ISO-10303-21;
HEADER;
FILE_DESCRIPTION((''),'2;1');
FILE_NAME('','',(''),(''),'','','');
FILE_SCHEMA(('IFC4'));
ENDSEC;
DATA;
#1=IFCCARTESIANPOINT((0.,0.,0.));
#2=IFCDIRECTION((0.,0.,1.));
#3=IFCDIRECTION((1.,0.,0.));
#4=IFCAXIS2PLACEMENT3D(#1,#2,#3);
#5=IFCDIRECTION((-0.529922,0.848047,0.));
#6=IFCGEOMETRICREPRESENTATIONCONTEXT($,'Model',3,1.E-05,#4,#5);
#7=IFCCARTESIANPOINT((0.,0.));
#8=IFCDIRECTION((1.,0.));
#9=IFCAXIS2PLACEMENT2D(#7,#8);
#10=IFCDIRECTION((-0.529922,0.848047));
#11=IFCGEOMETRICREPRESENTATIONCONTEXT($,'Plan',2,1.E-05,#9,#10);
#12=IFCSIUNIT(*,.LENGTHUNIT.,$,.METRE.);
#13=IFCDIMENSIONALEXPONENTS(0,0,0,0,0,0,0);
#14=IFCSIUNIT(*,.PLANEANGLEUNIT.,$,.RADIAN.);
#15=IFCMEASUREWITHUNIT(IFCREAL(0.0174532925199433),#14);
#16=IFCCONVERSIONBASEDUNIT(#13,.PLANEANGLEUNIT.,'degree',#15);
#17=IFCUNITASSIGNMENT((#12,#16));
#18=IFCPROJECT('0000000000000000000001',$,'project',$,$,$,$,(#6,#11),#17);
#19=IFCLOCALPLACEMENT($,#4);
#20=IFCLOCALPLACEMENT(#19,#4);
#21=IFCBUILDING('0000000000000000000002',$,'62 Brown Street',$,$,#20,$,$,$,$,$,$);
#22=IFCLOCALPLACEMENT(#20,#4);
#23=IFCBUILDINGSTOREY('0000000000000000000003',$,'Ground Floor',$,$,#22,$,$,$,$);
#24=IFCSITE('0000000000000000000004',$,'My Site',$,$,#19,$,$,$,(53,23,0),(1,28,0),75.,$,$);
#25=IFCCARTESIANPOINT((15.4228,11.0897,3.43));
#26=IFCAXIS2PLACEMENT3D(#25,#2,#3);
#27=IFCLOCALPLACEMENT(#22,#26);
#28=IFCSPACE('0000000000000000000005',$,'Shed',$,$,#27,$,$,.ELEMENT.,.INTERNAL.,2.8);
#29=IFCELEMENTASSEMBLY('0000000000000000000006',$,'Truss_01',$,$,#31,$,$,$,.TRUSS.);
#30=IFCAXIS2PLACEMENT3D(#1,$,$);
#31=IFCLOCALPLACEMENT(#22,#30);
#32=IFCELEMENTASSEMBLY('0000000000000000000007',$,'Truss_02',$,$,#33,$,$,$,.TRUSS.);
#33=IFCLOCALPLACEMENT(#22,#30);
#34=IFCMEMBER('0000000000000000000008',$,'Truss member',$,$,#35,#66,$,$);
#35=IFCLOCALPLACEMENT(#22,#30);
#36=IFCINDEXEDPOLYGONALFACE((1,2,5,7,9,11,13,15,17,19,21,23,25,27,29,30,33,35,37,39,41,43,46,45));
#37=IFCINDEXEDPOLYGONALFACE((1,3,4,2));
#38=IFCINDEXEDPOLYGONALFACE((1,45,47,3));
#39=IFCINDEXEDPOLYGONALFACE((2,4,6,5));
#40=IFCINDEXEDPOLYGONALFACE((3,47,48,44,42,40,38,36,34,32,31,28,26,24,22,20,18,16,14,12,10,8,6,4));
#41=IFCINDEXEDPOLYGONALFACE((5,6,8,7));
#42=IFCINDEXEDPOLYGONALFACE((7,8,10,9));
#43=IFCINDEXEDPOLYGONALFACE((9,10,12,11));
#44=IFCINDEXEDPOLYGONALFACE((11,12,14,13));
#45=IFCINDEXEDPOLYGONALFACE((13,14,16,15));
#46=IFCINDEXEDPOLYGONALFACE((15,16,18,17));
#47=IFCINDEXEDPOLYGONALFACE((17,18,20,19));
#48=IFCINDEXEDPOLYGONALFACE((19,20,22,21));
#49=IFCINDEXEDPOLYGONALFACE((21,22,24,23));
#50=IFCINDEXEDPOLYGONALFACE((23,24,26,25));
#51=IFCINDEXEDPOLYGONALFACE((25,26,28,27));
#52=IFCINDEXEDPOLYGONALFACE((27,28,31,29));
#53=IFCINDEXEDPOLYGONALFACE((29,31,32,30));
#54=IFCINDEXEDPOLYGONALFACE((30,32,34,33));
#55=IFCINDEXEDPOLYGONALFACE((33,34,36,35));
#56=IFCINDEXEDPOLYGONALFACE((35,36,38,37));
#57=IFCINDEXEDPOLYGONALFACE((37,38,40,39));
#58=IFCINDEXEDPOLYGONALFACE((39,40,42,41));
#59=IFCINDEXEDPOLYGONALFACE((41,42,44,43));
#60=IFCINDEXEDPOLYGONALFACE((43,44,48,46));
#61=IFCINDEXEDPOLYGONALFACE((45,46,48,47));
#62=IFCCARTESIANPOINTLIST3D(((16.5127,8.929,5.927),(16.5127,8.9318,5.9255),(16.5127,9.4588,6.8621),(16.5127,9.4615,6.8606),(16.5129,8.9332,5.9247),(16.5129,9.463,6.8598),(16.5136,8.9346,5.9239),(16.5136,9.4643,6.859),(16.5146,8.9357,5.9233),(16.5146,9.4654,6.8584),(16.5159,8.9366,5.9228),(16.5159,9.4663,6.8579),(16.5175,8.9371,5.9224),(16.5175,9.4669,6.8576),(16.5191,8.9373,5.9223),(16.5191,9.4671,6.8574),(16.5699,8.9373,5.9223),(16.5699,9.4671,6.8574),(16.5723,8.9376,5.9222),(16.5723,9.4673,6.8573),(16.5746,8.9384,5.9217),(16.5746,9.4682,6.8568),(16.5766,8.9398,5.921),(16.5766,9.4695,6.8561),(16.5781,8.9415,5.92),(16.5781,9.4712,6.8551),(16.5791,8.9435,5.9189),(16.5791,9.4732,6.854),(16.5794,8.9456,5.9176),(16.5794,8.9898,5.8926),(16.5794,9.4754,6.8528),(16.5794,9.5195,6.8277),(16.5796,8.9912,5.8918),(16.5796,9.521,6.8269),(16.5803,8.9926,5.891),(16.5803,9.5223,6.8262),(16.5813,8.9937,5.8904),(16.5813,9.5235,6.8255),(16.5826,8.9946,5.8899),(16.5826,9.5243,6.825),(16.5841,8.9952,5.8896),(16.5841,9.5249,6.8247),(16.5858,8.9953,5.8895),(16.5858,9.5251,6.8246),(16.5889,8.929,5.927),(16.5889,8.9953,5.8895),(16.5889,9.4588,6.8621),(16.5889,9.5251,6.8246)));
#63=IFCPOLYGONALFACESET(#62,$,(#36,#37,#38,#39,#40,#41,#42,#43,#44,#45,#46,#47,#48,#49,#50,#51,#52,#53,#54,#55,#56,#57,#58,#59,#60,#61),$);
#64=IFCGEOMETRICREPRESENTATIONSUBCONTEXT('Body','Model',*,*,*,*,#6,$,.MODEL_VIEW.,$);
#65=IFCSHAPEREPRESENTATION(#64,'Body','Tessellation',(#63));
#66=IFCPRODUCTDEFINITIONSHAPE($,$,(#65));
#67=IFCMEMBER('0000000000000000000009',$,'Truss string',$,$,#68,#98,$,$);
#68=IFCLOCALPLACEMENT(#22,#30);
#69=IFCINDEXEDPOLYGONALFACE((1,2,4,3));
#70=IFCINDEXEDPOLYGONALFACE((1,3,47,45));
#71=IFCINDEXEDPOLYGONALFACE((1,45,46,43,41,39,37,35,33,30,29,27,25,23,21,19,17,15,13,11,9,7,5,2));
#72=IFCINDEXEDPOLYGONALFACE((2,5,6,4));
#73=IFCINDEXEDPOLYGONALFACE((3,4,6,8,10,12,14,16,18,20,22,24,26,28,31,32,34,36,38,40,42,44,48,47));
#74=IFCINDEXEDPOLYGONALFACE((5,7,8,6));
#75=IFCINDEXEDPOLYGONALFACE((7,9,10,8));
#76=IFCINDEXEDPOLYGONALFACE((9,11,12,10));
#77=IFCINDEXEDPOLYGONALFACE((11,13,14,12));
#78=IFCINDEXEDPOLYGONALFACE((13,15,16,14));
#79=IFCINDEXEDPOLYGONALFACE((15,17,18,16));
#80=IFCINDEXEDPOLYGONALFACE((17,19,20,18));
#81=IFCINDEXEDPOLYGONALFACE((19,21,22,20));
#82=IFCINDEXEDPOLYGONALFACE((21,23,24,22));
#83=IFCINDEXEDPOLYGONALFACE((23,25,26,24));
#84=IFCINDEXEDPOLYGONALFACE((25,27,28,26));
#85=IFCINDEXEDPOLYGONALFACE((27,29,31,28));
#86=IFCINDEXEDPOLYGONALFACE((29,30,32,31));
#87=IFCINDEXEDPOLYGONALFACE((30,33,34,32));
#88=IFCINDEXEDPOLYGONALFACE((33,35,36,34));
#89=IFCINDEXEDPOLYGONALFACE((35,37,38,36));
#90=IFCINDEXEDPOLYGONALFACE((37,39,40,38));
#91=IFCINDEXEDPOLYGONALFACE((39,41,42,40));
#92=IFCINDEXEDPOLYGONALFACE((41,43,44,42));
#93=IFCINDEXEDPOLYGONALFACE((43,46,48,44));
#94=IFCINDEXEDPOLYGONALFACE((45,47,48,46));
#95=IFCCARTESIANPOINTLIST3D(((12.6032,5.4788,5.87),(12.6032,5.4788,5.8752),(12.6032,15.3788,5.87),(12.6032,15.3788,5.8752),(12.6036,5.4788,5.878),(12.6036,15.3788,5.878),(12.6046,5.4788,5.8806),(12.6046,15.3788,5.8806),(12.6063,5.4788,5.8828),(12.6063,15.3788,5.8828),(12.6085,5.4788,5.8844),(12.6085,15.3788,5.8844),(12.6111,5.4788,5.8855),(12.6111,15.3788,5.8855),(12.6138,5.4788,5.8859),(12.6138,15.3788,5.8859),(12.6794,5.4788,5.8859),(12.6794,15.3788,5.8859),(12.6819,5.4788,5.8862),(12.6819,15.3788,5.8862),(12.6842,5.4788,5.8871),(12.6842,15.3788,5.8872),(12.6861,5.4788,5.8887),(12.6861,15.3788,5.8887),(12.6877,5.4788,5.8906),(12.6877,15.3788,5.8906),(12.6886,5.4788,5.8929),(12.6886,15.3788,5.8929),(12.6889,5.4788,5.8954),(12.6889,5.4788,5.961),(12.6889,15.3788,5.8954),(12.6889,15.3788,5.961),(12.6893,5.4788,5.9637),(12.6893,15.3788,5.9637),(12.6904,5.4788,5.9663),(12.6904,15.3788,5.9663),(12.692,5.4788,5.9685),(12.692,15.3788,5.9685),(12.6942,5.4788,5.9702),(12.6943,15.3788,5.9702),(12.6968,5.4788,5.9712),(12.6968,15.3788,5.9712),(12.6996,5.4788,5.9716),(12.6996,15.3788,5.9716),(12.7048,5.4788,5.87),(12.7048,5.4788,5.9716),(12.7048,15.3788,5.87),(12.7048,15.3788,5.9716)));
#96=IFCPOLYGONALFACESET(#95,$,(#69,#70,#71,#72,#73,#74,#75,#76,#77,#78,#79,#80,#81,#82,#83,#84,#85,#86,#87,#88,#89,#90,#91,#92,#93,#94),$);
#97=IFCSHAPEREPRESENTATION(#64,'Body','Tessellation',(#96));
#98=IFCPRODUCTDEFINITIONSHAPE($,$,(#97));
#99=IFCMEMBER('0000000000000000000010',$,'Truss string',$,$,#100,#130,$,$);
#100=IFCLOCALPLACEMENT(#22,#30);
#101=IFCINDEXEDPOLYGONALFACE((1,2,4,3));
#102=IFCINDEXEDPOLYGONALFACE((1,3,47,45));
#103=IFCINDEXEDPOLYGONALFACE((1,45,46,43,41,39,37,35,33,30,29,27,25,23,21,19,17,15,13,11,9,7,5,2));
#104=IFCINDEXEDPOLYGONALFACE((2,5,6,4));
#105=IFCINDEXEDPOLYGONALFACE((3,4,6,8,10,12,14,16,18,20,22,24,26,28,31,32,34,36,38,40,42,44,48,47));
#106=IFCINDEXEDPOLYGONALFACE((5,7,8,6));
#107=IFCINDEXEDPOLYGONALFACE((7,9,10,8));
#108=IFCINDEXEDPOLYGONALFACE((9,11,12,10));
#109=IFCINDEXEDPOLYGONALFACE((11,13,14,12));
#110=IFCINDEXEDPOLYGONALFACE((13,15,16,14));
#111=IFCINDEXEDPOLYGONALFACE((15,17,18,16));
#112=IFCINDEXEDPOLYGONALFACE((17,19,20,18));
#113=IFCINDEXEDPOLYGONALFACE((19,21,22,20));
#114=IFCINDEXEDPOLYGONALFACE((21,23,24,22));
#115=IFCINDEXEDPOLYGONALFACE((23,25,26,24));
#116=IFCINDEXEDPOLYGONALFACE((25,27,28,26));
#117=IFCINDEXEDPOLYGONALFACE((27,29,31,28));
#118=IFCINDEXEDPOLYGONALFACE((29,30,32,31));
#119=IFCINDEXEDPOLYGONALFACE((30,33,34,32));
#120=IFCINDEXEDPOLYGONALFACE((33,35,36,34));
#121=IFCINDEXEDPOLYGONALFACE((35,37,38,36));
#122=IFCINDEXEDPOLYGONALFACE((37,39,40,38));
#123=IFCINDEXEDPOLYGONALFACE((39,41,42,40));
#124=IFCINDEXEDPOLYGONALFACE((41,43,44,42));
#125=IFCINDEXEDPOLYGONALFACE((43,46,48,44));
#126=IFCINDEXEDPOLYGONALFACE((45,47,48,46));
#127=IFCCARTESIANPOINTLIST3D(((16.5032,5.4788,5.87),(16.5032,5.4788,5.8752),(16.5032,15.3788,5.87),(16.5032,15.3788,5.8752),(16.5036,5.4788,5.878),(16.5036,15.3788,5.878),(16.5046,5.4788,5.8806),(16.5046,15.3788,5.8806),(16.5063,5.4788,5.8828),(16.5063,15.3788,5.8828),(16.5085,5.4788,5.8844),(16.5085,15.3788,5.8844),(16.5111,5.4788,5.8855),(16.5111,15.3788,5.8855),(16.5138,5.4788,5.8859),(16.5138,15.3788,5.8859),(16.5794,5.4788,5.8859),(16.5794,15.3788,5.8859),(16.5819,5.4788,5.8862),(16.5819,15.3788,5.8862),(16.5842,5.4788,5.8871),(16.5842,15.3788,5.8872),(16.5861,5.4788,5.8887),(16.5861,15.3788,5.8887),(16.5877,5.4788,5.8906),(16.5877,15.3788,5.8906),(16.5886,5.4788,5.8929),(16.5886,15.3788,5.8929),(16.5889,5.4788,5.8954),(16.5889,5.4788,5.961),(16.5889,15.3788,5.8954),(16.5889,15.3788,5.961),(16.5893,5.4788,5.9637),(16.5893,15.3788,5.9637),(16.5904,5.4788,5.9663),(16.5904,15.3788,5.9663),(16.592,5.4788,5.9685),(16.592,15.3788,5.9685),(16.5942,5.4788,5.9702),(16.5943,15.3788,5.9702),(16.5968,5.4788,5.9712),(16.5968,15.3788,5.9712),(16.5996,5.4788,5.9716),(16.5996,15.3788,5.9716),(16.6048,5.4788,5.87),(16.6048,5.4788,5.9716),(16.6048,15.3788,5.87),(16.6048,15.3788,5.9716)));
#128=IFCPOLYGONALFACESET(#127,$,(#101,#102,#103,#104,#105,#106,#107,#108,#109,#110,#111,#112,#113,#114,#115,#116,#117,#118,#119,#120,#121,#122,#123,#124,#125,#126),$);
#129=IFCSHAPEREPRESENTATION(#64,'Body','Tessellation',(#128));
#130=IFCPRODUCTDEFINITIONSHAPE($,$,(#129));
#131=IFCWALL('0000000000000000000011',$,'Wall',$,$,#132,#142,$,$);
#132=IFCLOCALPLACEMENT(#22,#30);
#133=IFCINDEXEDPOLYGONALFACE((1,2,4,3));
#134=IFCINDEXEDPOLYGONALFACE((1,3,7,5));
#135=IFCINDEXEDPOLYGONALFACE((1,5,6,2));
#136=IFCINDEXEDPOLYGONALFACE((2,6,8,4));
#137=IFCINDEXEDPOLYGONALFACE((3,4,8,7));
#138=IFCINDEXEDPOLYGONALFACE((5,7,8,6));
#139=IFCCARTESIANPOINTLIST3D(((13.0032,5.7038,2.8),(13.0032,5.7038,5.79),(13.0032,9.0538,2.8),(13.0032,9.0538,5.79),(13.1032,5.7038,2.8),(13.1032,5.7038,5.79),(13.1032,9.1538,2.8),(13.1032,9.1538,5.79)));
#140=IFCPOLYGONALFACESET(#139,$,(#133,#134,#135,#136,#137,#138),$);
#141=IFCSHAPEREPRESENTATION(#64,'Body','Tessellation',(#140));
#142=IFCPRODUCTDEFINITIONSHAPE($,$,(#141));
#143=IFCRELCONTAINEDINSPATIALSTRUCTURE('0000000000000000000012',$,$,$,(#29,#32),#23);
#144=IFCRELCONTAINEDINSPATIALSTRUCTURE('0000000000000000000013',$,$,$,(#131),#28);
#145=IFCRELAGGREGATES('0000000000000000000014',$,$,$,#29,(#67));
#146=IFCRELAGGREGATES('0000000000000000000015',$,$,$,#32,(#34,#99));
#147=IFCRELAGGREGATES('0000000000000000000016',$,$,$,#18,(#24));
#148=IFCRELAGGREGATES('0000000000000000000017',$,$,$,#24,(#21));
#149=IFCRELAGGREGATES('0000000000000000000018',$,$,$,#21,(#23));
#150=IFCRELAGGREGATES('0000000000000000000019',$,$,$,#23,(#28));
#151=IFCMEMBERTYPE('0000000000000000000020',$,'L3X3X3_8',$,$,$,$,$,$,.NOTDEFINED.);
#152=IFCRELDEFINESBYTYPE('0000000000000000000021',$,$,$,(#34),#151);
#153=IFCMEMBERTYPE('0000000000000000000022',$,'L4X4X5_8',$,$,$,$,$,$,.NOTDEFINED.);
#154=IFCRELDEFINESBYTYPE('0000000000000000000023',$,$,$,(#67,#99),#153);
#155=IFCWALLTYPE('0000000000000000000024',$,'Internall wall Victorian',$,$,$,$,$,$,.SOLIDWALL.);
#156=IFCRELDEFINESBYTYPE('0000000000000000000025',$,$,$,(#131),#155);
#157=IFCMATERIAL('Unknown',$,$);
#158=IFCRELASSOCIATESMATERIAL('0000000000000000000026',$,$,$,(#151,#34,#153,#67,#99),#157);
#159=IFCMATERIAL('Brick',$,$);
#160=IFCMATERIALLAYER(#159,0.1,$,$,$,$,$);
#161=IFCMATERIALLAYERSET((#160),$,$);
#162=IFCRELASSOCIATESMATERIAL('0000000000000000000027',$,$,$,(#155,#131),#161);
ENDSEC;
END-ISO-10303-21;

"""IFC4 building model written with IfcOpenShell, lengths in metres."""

from ifc_helpers import new_model, entity, si_unit, converted_unit, direction, frame, origin_with_axes, origin_2d_with_axis, place, context, subcontext, project, spatial, indexed_curve, l_section, outline, extrude, clip, halfspace, material, layer, layer_set, layer_usage, material_profile, profile_set, profile_usage, type_object, element, aggregate, save


model = new_model("IFC4")

# Units and contexts
model_context = context("Model", 3, precision=1e-05, world=origin_with_axes(), true_north=direction((-0.529922, 0.848047, 0.0)))
plan_context = context("Plan", 2, precision=1e-05, world=origin_2d_with_axis(), true_north=direction((-0.529922, 0.848047)))
body_context_1 = subcontext(model_context, "Body", "Model", "MODEL_VIEW")
ifc_project = project(units=[si_unit("LENGTHUNIT", "METRE"), converted_unit("PLANEANGLEUNIT", "degree", entity("IfcReal", 0.0174532925199433), si_unit("PLANEANGLEUNIT", "RADIAN"), dimensions=[0, 0, 0, 0, 0, 0, 0])], contexts=[model_context, plan_context])

# Site, building, storey
site_placement = place(None, origin_with_axes())
site = spatial("IfcSite", under=ifc_project, at=site_placement, Name="My Site", RefLatitude=(53, 23, 0), RefLongitude=(1, 28, 0), RefElevation=75.0)
building_placement = place(site_placement, origin_with_axes())
building = spatial("IfcBuilding", under=site, at=building_placement, Name="62 Brown Street")
storey_placement = place(building_placement, origin_with_axes())
storey = spatial("IfcBuildingStorey", under=building, at=storey_placement, Name="Ground Floor")

# Element assemblies, member
ifc_material_1 = material(Name="Unknown")
ifc_material_profile_1 = material_profile(ifc_material_1, l_section(Depth=0.0762, Width=0.0762, Thickness=0.0095, FilletRadius=0.0095, EdgeRadius=0.0064))
ifc_profile_set_1 = profile_set([ifc_material_profile_1])
member_type_1 = type_object("IfcMemberType", Name="L3X3X3_8", PredefinedType="NOTDEFINED", material=ifc_profile_set_1)
assembly_1_placement = place(storey_placement, frame((12.7032, 10.4288, 6.9738), z_axis=(0.0, 0.0, 1.0), x_axis=(1.0, 0.0, 0.0)))
assembly_1 = element("IfcElementAssembly", 1, at=assembly_1_placement, inside=storey, Name="Truss_01", PredefinedType="TRUSS")
assembly_2_placement = place(storey_placement, frame((16.6032, 10.4288, 6.9738), z_axis=(0.0, 0.0, 1.0), x_axis=(1.0, 0.0, 0.0)))
assembly_2 = element("IfcElementAssembly", 2, at=assembly_2_placement, inside=storey, Name="Truss_02", PredefinedType="TRUSS")
ifc_profile_usage_1 = profile_usage(ifc_profile_set_1, cardinal=5)
member_1_placement = place(assembly_2_placement, frame((-0.0524, -0.9369, -0.1304), z_axis=(0.0, -0.492899, -0.870086), x_axis=(-1.0, 0.0, 0.0)))
member_1 = element("IfcMember", 3, at=member_1_placement, type_object=member_type_1, material=ifc_profile_usage_1, Name="Truss member", context=body_context_1, shape_type="SweptSolid", body=[
    extrude(l_section(Depth=0.0762, Width=0.0762, Thickness=0.0095, FilletRadius=0.0095, EdgeRadius=0.0064), origin_with_axes(), (0.0, 0.0, 1.0), 1.0747),
])

# Members
ifc_material_profile_2 = material_profile(ifc_material_1, l_section(Depth=0.1016, Width=0.1016, Thickness=0.0159, FilletRadius=0.0095, EdgeRadius=0.0106))
ifc_profile_set_2 = profile_set([ifc_material_profile_2])
ifc_profile_usage_2 = profile_usage(ifc_profile_set_2, cardinal=5)
member_type_2 = type_object("IfcMemberType", Name="L4X4X5_8", PredefinedType="NOTDEFINED", material=ifc_profile_set_2)
member_2_placement = place(assembly_1_placement, frame((-0.0492, -4.95, -1.053), z_axis=(0.0, 1.0, 0.0), x_axis=(-1.0, 0.0, 0.0)))
member_2 = element("IfcMember", 4, at=member_2_placement, type_object=member_type_2, material=ifc_profile_usage_2, Name="Truss string", context=body_context_1, shape_type="SweptSolid", body=[
    extrude(l_section(Depth=0.1016, Width=0.1016, Thickness=0.0159, FilletRadius=0.0095, EdgeRadius=0.0106), origin_with_axes(), (0.0, 0.0, 1.0), 9.9),
])
aggregate(assembly_1, [member_2])
ifc_profile_usage_3 = profile_usage(ifc_profile_set_2, cardinal=5)
member_3_placement = place(assembly_2_placement, frame((-0.0492, -4.95, -1.053), z_axis=(0.0, 1.0, 0.0), x_axis=(-1.0, 0.0, 0.0)))
member_3 = element("IfcMember", 5, at=member_3_placement, type_object=member_type_2, material=ifc_profile_usage_3, Name="Truss string", context=body_context_1, shape_type="SweptSolid", body=[
    extrude(l_section(Depth=0.1016, Width=0.1016, Thickness=0.0159, FilletRadius=0.0095, EdgeRadius=0.0106), origin_with_axes(), (0.0, 0.0, 1.0), 9.9),
])
aggregate(assembly_2, [member_1, member_3])

# Shared definitions
space_placement = place(storey_placement, frame((15.4228, 11.0897, 3.43), z_axis=(0.0, 0.0, 1.0), x_axis=(1.0, 0.0, 0.0)))
space = spatial("IfcSpace", under=storey, at=space_placement, Name="Shed", CompositionType="ELEMENT", PredefinedType="INTERNAL", ElevationWithFlooring=2.8)

# Wall
ifc_material_2 = material(Name="Brick")
ifc_layer_1 = layer(ifc_material_2, 0.1)
ifc_layer_set_1 = layer_set([ifc_layer_1])
ifc_layer_usage_1 = layer_usage(ifc_layer_set_1, "AXIS2", "POSITIVE", 0.0)
wall_type = type_object("IfcWallType", Name="Internall wall Victorian", PredefinedType="SOLIDWALL", material=ifc_layer_set_1)
wall_1_placement = place(None, frame((13.1032, 5.7038, 2.8), z_axis=(0.0, 0.0, 1.0), x_axis=(0.0, 1.0, 0.0)))
element("IfcWall", 6, at=wall_1_placement, inside=space, type_object=wall_type, material=ifc_layer_usage_1, Name="Wall", context=body_context_1, shape_type="Clipping", body=[
    clip(extrude(outline(indexed_curve([(0.0, 0.0), (0.0, 0.1), (3.45, 0.1), (3.45, 0.0), (0.0, 0.0)], self_intersect=False)), origin_with_axes(), (0.0, 0.0, 1.0), 2.99), halfspace(frame((3.45, 0.0, -2.8), z_axis=(0.70711, 0.707104, 0.0), x_axis=(0.707104, -0.70711, 0.0)), False)),
])

save(model, "model.ifc")
